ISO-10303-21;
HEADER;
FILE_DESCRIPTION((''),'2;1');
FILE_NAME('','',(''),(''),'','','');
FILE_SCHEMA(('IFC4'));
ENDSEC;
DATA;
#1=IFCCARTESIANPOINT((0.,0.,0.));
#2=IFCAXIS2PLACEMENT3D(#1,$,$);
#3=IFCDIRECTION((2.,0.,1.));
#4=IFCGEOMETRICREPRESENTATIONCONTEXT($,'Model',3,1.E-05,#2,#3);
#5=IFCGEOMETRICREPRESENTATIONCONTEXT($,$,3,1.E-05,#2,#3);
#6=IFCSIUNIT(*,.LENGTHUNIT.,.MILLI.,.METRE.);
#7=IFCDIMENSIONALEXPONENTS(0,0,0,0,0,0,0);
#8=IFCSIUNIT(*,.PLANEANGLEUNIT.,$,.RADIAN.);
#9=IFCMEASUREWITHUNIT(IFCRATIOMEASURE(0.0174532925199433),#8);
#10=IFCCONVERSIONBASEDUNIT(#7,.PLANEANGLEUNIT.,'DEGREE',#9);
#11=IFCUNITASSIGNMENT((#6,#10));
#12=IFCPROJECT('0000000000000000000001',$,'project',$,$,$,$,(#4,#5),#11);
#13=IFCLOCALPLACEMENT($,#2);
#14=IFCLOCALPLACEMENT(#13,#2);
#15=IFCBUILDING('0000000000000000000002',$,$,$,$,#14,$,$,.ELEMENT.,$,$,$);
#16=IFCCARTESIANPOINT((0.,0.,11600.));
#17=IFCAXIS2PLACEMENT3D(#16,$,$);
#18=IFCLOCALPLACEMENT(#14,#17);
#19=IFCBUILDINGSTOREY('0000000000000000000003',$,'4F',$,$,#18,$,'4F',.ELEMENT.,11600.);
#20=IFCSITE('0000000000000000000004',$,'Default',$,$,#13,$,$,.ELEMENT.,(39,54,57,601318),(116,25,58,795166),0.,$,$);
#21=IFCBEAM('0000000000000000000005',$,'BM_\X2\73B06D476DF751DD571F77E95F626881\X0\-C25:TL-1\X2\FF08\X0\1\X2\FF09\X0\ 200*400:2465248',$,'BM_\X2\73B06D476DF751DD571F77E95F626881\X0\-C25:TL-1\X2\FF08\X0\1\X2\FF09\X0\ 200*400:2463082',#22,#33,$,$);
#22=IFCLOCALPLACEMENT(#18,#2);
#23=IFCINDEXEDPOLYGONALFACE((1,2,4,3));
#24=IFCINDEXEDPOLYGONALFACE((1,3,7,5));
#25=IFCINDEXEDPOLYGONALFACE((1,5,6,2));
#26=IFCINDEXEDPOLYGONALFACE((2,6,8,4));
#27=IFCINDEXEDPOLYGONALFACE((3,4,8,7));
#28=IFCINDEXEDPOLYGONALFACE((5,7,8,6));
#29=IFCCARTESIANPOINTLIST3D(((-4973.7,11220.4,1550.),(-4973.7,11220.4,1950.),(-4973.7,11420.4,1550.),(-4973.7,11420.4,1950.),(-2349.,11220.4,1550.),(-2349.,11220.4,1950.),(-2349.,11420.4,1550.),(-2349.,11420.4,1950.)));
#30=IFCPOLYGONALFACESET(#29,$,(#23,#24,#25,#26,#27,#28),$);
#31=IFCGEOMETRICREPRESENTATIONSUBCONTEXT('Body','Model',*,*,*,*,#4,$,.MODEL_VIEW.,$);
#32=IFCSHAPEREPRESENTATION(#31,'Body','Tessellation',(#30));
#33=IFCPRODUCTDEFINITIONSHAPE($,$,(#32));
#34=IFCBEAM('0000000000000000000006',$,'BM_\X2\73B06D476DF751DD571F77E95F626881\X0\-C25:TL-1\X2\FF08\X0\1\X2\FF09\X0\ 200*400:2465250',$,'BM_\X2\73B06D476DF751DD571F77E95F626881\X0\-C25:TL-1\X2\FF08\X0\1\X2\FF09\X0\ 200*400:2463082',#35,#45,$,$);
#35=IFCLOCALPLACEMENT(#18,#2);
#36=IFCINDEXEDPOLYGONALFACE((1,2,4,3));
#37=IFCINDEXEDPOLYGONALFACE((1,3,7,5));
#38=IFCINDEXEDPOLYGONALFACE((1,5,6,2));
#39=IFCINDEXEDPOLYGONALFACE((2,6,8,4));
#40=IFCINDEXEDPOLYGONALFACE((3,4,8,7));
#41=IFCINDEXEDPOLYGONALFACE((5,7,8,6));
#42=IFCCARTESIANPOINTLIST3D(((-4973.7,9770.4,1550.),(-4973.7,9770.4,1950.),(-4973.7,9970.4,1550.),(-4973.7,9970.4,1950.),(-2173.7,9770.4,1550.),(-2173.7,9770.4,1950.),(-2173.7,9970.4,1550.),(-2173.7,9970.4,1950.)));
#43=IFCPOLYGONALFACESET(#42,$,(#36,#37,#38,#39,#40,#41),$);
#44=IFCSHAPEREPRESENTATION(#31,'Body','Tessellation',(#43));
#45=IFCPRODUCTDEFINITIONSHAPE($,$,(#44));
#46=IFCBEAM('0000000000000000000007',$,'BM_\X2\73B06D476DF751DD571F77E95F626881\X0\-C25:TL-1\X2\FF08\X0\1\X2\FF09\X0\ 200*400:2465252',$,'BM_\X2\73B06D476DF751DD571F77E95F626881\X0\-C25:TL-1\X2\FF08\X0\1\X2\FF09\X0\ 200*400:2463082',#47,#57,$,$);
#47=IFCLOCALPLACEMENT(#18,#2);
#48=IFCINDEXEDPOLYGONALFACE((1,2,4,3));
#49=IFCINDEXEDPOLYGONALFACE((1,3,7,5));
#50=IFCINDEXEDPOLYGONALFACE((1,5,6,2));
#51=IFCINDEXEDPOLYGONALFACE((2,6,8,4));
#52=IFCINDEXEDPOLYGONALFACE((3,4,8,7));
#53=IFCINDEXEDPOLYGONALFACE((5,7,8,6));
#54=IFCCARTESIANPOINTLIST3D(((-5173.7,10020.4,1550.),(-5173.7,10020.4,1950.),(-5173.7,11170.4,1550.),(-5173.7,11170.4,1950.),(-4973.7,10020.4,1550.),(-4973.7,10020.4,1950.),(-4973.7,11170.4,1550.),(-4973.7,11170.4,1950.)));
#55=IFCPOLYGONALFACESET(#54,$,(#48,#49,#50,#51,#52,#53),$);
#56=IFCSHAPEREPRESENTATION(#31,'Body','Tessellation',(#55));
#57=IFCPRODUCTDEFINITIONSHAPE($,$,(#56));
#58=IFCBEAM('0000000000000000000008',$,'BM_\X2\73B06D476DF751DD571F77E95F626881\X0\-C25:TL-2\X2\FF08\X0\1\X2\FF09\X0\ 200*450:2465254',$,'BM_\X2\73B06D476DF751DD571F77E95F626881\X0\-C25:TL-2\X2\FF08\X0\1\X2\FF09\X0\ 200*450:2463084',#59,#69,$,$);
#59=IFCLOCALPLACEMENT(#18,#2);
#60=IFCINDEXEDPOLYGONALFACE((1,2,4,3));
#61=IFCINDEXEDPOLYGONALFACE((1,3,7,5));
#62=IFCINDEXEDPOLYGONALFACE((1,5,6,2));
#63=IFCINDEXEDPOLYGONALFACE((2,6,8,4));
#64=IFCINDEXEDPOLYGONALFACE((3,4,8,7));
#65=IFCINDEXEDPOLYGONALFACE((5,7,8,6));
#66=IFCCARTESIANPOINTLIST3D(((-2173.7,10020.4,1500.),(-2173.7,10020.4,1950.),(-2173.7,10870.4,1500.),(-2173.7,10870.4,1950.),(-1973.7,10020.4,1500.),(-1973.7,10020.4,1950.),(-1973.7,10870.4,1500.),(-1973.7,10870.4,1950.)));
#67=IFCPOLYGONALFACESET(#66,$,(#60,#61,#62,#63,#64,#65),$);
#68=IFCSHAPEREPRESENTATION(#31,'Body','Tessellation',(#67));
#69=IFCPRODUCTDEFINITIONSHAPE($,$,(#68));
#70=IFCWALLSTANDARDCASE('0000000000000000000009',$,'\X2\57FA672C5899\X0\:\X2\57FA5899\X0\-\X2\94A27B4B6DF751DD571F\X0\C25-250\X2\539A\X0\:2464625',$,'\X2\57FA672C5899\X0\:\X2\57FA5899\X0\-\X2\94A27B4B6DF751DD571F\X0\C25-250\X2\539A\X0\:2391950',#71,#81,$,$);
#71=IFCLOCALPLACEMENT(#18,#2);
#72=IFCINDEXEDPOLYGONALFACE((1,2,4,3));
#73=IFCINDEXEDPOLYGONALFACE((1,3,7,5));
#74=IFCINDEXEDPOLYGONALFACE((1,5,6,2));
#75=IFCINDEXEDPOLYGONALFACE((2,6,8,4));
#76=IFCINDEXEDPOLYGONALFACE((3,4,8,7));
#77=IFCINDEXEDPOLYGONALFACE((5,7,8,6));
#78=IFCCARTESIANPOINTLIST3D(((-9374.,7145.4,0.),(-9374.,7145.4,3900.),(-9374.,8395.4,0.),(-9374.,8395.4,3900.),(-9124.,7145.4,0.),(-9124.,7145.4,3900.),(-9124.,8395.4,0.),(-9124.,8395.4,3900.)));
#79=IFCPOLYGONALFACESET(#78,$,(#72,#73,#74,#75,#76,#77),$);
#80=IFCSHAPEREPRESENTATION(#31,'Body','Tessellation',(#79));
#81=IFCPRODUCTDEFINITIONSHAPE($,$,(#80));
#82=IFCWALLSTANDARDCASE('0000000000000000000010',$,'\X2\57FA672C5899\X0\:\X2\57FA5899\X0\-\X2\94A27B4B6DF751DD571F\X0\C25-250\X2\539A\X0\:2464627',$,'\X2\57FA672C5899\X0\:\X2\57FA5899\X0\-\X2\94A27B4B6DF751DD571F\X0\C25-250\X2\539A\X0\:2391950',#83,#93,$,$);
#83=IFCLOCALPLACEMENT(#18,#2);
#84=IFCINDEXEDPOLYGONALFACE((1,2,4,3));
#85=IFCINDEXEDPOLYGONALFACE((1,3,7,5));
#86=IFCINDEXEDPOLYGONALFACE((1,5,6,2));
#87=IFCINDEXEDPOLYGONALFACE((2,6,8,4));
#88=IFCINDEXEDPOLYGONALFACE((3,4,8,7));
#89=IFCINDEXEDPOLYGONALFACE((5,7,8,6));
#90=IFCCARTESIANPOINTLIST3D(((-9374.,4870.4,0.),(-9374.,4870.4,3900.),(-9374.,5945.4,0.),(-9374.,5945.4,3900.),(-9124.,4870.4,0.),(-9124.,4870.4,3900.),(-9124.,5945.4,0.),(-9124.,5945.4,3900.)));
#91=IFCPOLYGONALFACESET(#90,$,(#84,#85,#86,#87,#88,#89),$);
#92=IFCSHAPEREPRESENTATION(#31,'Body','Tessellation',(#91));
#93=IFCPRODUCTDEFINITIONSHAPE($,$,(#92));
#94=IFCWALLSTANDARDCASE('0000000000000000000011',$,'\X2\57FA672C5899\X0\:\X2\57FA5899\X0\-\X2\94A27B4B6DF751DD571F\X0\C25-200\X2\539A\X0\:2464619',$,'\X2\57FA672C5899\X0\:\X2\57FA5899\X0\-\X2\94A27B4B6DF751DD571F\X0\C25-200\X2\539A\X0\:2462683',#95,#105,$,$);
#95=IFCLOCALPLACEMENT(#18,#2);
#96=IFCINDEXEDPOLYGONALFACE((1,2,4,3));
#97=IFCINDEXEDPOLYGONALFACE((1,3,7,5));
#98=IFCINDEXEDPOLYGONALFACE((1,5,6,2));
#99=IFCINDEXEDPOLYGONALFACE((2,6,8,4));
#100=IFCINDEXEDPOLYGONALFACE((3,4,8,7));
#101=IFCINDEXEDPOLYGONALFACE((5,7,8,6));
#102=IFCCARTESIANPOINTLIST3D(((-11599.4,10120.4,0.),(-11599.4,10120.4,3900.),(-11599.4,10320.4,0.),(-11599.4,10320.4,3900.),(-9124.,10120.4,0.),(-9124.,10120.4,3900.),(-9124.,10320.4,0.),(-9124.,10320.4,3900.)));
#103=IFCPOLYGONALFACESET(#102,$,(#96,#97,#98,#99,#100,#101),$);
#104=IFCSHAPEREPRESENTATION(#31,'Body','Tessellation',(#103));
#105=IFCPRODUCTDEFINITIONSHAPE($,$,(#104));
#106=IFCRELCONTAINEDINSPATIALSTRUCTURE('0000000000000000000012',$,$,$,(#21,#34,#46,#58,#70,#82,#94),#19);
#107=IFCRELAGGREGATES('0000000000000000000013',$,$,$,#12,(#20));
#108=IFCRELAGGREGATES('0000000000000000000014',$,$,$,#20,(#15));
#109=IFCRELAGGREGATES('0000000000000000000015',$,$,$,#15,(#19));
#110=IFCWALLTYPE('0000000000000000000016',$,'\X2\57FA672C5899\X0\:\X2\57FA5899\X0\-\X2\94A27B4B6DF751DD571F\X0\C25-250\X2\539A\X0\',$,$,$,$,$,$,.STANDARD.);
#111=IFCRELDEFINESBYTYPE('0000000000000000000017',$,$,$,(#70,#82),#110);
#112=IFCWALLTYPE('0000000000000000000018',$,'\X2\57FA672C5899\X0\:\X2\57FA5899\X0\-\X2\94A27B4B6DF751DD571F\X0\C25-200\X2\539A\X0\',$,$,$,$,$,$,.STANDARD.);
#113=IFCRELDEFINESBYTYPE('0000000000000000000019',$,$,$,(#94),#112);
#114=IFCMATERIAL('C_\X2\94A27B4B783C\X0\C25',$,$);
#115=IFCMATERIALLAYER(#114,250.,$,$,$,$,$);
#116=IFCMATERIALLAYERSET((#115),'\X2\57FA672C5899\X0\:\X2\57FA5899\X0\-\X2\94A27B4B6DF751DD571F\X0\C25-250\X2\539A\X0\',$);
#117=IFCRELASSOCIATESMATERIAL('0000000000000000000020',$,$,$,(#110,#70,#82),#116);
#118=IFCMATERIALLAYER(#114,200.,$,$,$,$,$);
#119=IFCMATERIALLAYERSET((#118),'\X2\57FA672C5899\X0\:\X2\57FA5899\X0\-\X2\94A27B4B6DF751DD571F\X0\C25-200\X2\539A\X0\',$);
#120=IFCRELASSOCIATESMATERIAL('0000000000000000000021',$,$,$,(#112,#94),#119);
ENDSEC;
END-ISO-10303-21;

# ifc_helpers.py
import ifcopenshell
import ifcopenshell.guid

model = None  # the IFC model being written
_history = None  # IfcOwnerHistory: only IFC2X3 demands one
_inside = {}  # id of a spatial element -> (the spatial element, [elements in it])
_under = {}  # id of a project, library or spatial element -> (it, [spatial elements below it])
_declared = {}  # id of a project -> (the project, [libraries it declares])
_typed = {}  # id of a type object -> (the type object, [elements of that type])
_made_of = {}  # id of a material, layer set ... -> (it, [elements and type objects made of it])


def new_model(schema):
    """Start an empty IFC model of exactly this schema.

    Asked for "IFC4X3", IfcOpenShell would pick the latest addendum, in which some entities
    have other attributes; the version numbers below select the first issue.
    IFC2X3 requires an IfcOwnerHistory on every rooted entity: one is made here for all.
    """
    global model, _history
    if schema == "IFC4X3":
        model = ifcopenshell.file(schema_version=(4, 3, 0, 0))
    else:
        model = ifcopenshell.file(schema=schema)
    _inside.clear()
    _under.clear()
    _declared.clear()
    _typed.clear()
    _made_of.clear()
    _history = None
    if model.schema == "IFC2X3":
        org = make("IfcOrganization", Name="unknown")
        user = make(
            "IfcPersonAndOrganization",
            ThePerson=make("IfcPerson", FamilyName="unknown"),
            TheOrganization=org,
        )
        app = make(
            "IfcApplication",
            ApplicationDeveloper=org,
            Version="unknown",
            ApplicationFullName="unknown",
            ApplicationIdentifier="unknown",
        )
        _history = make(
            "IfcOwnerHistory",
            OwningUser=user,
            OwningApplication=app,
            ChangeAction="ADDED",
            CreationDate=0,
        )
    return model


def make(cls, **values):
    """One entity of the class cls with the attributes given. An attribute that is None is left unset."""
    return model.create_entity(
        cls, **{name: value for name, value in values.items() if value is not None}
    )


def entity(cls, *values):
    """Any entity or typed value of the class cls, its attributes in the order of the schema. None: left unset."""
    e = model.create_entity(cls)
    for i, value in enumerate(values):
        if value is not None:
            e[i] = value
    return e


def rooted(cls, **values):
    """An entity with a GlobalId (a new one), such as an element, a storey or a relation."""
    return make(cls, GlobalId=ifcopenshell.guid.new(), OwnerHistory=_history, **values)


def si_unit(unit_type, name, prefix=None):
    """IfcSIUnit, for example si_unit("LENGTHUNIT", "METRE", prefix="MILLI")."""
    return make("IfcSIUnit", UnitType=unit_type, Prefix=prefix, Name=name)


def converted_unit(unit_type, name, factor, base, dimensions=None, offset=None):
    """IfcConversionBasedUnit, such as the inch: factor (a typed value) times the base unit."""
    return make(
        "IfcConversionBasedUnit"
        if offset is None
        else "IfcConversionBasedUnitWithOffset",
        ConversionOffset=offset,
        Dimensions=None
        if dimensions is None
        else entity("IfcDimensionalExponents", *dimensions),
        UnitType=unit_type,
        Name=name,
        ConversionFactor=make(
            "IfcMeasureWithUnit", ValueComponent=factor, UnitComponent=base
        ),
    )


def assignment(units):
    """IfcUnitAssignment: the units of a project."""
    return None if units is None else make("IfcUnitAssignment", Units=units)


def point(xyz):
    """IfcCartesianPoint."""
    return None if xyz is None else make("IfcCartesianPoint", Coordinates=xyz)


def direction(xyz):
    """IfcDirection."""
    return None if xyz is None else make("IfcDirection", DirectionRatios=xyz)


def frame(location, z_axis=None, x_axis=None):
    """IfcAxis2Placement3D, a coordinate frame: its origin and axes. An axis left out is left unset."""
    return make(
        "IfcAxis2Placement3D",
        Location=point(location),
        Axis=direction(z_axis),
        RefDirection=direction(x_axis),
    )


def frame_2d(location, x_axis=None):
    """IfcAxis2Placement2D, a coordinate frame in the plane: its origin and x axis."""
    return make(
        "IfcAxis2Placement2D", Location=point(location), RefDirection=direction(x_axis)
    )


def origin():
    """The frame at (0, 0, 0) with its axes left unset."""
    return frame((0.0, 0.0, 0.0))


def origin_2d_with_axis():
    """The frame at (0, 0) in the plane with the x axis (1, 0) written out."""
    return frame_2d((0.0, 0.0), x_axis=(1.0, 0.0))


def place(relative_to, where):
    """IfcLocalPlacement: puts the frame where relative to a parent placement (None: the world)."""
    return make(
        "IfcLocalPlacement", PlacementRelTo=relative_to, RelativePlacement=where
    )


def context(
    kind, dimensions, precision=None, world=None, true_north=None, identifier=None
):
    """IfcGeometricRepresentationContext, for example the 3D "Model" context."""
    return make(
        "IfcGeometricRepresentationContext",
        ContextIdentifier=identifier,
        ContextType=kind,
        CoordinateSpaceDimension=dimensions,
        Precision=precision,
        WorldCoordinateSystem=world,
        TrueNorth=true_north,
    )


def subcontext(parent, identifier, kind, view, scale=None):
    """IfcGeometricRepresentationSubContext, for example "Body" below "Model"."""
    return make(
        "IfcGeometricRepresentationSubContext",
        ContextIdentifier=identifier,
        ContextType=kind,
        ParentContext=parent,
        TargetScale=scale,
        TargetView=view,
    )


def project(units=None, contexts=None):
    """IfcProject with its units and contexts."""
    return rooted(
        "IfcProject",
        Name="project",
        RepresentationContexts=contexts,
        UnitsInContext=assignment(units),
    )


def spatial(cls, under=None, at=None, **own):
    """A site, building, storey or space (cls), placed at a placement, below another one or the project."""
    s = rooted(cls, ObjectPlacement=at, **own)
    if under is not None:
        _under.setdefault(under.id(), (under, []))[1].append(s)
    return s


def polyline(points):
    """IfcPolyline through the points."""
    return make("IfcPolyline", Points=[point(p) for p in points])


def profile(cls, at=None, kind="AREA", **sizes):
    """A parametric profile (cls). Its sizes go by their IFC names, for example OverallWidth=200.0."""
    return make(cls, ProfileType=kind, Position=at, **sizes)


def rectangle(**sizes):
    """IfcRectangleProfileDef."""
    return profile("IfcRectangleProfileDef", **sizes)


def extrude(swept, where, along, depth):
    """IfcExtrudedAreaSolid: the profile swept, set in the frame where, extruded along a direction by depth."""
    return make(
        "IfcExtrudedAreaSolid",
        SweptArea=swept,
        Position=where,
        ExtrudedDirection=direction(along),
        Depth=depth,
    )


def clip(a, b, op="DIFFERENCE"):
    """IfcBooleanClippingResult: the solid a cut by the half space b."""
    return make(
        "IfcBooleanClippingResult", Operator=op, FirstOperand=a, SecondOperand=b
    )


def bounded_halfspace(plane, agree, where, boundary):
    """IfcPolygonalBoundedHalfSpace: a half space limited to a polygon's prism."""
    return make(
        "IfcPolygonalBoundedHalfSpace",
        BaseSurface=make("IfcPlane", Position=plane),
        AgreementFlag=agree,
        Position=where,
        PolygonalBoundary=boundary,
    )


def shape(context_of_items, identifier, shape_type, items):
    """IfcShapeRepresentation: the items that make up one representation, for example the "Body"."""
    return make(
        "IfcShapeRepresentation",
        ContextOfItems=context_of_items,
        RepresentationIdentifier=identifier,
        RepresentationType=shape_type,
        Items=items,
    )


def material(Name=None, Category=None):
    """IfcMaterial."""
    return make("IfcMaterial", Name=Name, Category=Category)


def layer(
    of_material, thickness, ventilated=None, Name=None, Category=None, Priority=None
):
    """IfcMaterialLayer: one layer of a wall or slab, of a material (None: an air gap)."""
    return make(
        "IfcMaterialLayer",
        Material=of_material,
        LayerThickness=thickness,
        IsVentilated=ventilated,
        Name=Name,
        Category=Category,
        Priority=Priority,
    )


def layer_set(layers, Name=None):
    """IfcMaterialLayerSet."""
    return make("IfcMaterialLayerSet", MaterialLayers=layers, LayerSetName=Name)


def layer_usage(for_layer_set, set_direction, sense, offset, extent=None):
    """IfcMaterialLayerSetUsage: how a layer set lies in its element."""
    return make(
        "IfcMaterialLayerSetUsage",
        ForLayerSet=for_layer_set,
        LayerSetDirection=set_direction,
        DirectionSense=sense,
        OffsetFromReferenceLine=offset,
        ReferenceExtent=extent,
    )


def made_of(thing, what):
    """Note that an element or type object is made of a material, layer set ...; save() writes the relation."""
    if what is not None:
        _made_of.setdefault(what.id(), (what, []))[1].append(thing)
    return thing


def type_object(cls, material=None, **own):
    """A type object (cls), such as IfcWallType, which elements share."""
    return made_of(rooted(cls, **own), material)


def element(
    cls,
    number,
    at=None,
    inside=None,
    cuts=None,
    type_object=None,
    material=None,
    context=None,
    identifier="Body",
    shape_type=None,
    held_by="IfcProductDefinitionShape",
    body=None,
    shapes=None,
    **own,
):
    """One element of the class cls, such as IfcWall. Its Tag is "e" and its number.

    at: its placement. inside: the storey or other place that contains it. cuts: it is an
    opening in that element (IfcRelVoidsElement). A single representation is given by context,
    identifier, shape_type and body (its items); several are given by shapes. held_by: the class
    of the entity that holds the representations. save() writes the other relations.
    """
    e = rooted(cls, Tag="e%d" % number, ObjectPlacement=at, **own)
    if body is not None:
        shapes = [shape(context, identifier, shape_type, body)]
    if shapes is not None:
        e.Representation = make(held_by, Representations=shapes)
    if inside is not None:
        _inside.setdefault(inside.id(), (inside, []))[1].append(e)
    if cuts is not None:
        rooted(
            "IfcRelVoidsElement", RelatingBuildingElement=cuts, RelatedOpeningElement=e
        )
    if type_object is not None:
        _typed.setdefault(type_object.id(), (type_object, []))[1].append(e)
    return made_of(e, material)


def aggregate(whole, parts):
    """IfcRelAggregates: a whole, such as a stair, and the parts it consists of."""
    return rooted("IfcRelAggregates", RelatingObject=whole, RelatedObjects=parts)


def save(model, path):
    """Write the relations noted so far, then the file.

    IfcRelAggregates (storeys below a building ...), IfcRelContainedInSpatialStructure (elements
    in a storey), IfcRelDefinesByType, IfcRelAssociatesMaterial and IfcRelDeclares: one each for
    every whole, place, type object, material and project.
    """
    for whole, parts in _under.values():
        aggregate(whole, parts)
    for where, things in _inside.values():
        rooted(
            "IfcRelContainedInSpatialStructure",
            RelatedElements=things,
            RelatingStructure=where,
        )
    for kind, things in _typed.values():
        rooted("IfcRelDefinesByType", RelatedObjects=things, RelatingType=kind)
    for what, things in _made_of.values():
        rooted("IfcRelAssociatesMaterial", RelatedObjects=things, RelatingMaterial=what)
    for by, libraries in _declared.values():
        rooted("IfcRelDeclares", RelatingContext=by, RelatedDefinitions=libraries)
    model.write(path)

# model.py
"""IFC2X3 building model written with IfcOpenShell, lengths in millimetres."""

from ifc_helpers import new_model, entity, si_unit, converted_unit, direction, frame, frame_2d, origin, origin_2d_with_axis, place, context, subcontext, project, spatial, polyline, rectangle, extrude, clip, bounded_halfspace, material, layer, layer_set, layer_usage, type_object, element, save


model = new_model("IFC2X3")

# Units and contexts
model_context = context("Model", 3, precision=1e-05, world=origin(), true_north=direction((2.0, 0.0, 1.0)))
context_of_model = context(None, 3, precision=1e-05, world=origin(), true_north=direction((2.0, 0.0, 1.0)))
body_context = subcontext(model_context, "Body", "Model", "MODEL_VIEW")
ifc_project = project(units=[si_unit("LENGTHUNIT", "METRE", prefix="MILLI"), converted_unit("PLANEANGLEUNIT", "DEGREE", entity("IfcRatioMeasure", 0.0174532925199433), si_unit("PLANEANGLEUNIT", "RADIAN"), dimensions=[0, 0, 0, 0, 0, 0, 0])], contexts=[model_context, context_of_model])

# Site, building, storey
site_placement = place(None, origin())
site = spatial("IfcSite", under=ifc_project, at=site_placement, Name="Default", CompositionType="ELEMENT", RefLatitude=(39, 54, 57, 601318), RefLongitude=(116, 25, 58, 795166), RefElevation=0.0)
building_placement = place(site_placement, origin())
building = spatial("IfcBuilding", under=site, at=building_placement, CompositionType="ELEMENT")
storey_placement = place(building_placement, frame((0.0, 0.0, 11600.0)))
storey = spatial("IfcBuildingStorey", under=building, at=storey_placement, Name="4F", LongName="4F", CompositionType="ELEMENT", Elevation=11600.0)

# Shared definitions
ifc_material = material(Name="C_钢筋砼C25")

# Beams
beam_1_placement = place(storey_placement, frame((-5073.7, 11320.4, 1950.0)))
element("IfcBeam", 1, at=beam_1_placement, inside=storey, Name="BM_现浇混凝土矩形梁-C25:TL-1（1） 200*400:2465248", ObjectType="BM_现浇混凝土矩形梁-C25:TL-1（1） 200*400:2463082", context=body_context, shape_type="SweptSolid", body=[
    extrude(rectangle(XDim=400.0, YDim=200.0, at=frame_2d((0.0, 0.0), x_axis=(1.0, 0.0))), frame((100.0, 0.0, -200.0), z_axis=(1.0, 0.0, 0.0), x_axis=(0.0, 0.0, -1.0)), (0.0, 0.0, 1.0), 2624.6),
])
beam_2_placement = place(storey_placement, frame((-5073.7, 9870.4, 1950.0)))
element("IfcBeam", 2, at=beam_2_placement, inside=storey, Name="BM_现浇混凝土矩形梁-C25:TL-1（1） 200*400:2465250", ObjectType="BM_现浇混凝土矩形梁-C25:TL-1（1） 200*400:2463082", context=body_context, shape_type="SweptSolid", body=[
    extrude(rectangle(XDim=400.0, YDim=200.0, at=frame_2d((0.0, 0.0), x_axis=(1.0, 0.0))), frame((100.0, 0.0, -200.0), z_axis=(1.0, 0.0, 0.0), x_axis=(0.0, 0.0, -1.0)), (0.0, 0.0, 1.0), 2800.0),
])
beam_3_placement = place(storey_placement, frame((-5073.7, 11195.4, 1950.0), z_axis=(0.0, 0.0, 1.0), x_axis=(0.0, -1.0, 0.0)))
element("IfcBeam", 3, at=beam_3_placement, inside=storey, Name="BM_现浇混凝土矩形梁-C25:TL-1（1） 200*400:2465252", ObjectType="BM_现浇混凝土矩形梁-C25:TL-1（1） 200*400:2463082", context=body_context, shape_type="SweptSolid", body=[
    extrude(rectangle(XDim=400.0, YDim=200.0, at=origin_2d_with_axis()), frame((25.0, 0.0, -200.0), z_axis=(1.0, 0.0, 0.0), x_axis=(0.0, 0.0, -1.0)), (0.0, 0.0, 1.0), 1150.0),
])
beam_4_placement = place(storey_placement, frame((-2073.7, 11195.4, 1950.0), z_axis=(0.0, 0.0, 1.0), x_axis=(0.0, -1.0, 0.0)))
element("IfcBeam", 4, at=beam_4_placement, inside=storey, Name="BM_现浇混凝土矩形梁-C25:TL-2（1） 200*450:2465254", ObjectType="BM_现浇混凝土矩形梁-C25:TL-2（1） 200*450:2463084", context=body_context, shape_type="SweptSolid", body=[
    extrude(rectangle(XDim=450.0, YDim=200.0, at=frame_2d((0.0, 0.0), x_axis=(1.0, 0.0))), frame((325.0, 0.0, -225.0), z_axis=(1.0, 0.0, 0.0), x_axis=(0.0, 0.0, -1.0)), (0.0, 0.0, 1.0), 850.0),
])

# Walls
ifc_layer_1 = layer(ifc_material, 250.0)
ifc_layer_set_1 = layer_set([ifc_layer_1], Name="基本墙:基墙-钢筋混凝土C25-250厚")
ifc_layer_usage_1 = layer_usage(ifc_layer_set_1, "AXIS2", "NEGATIVE", 125.0)
wall_type_1 = type_object("IfcWallType", Name="基本墙:基墙-钢筋混凝土C25-250厚", PredefinedType="STANDARD", material=ifc_layer_set_1)
wall_1_placement = place(storey_placement, frame((-9249.0, 8395.4, 0.0), z_axis=(0.0, 0.0, 1.0), x_axis=(0.0, -1.0, 0.0)))
element("IfcWallStandardCase", 5, at=wall_1_placement, inside=storey, type_object=wall_type_1, material=ifc_layer_usage_1, Name="基本墙:基墙-钢筋混凝土C25-250厚:2464625", ObjectType="基本墙:基墙-钢筋混凝土C25-250厚:2391950", context=body_context, shape_type="SweptSolid", body=[
    extrude(rectangle(XDim=1250.0, YDim=250.0, at=frame_2d((625.0, 0.0), x_axis=(-1.0, 0.0))), origin(), (0.0, 0.0, 1.0), 3900.0),
])
ifc_layer_usage_2 = layer_usage(ifc_layer_set_1, "AXIS2", "NEGATIVE", 125.0)
wall_2_placement = place(storey_placement, frame((-9249.0, 5945.4, 0.0), z_axis=(0.0, 0.0, 1.0), x_axis=(0.0, -1.0, 0.0)))
element("IfcWallStandardCase", 6, at=wall_2_placement, inside=storey, type_object=wall_type_1, material=ifc_layer_usage_2, Name="基本墙:基墙-钢筋混凝土C25-250厚:2464627", ObjectType="基本墙:基墙-钢筋混凝土C25-250厚:2391950", context=body_context, shape_type="Clipping", body=[
    clip(extrude(rectangle(XDim=1075.0, YDim=250.0, at=frame_2d((537.5, 0.0), x_axis=(-1.0, 0.0))), origin(), (0.0, 0.0, 1.0), 3900.0), bounded_halfspace(frame((1075.0, -125.0, 3900.0), z_axis=(-1.0, 0.0, 0.0), x_axis=(0.0, 0.0, -1.0)), True, frame((1075.0, -125.0, 3900.0), z_axis=(-1.0, 0.0, 0.0), x_axis=(0.0, 0.0, -1.0)), polyline([(0.0, 0.0), (0.0, -250.0), (150.0, -250.0), (3900.0, -250.0), (3900.0, 0.0), (150.0, 0.0), (0.0, 0.0)]))),
])
ifc_layer_2 = layer(ifc_material, 200.0)
ifc_layer_set_2 = layer_set([ifc_layer_2], Name="基本墙:基墙-钢筋混凝土C25-200厚")
ifc_layer_usage_3 = layer_usage(ifc_layer_set_2, "AXIS2", "NEGATIVE", 100.0)
wall_type_2 = type_object("IfcWallType", Name="基本墙:基墙-钢筋混凝土C25-200厚", PredefinedType="STANDARD", material=ifc_layer_set_2)
wall_3_placement = place(storey_placement, frame((-9124.0, 10220.4, 0.0), z_axis=(0.0, 0.0, 1.0), x_axis=(-1.0, 0.0, 0.0)))
element("IfcWallStandardCase", 7, at=wall_3_placement, inside=storey, type_object=wall_type_2, material=ifc_layer_usage_3, Name="基本墙:基墙-钢筋混凝土C25-200厚:2464619", ObjectType="基本墙:基墙-钢筋混凝土C25-200厚:2462683", context=body_context, shape_type="SweptSolid", body=[
    extrude(rectangle(XDim=2475.4, YDim=200.0, at=frame_2d((1237.7, 0.0), x_axis=(-1.0, 0.0))), origin(), (0.0, 0.0, 1.0), 3900.0),
])

save(model, "model.ifc")
